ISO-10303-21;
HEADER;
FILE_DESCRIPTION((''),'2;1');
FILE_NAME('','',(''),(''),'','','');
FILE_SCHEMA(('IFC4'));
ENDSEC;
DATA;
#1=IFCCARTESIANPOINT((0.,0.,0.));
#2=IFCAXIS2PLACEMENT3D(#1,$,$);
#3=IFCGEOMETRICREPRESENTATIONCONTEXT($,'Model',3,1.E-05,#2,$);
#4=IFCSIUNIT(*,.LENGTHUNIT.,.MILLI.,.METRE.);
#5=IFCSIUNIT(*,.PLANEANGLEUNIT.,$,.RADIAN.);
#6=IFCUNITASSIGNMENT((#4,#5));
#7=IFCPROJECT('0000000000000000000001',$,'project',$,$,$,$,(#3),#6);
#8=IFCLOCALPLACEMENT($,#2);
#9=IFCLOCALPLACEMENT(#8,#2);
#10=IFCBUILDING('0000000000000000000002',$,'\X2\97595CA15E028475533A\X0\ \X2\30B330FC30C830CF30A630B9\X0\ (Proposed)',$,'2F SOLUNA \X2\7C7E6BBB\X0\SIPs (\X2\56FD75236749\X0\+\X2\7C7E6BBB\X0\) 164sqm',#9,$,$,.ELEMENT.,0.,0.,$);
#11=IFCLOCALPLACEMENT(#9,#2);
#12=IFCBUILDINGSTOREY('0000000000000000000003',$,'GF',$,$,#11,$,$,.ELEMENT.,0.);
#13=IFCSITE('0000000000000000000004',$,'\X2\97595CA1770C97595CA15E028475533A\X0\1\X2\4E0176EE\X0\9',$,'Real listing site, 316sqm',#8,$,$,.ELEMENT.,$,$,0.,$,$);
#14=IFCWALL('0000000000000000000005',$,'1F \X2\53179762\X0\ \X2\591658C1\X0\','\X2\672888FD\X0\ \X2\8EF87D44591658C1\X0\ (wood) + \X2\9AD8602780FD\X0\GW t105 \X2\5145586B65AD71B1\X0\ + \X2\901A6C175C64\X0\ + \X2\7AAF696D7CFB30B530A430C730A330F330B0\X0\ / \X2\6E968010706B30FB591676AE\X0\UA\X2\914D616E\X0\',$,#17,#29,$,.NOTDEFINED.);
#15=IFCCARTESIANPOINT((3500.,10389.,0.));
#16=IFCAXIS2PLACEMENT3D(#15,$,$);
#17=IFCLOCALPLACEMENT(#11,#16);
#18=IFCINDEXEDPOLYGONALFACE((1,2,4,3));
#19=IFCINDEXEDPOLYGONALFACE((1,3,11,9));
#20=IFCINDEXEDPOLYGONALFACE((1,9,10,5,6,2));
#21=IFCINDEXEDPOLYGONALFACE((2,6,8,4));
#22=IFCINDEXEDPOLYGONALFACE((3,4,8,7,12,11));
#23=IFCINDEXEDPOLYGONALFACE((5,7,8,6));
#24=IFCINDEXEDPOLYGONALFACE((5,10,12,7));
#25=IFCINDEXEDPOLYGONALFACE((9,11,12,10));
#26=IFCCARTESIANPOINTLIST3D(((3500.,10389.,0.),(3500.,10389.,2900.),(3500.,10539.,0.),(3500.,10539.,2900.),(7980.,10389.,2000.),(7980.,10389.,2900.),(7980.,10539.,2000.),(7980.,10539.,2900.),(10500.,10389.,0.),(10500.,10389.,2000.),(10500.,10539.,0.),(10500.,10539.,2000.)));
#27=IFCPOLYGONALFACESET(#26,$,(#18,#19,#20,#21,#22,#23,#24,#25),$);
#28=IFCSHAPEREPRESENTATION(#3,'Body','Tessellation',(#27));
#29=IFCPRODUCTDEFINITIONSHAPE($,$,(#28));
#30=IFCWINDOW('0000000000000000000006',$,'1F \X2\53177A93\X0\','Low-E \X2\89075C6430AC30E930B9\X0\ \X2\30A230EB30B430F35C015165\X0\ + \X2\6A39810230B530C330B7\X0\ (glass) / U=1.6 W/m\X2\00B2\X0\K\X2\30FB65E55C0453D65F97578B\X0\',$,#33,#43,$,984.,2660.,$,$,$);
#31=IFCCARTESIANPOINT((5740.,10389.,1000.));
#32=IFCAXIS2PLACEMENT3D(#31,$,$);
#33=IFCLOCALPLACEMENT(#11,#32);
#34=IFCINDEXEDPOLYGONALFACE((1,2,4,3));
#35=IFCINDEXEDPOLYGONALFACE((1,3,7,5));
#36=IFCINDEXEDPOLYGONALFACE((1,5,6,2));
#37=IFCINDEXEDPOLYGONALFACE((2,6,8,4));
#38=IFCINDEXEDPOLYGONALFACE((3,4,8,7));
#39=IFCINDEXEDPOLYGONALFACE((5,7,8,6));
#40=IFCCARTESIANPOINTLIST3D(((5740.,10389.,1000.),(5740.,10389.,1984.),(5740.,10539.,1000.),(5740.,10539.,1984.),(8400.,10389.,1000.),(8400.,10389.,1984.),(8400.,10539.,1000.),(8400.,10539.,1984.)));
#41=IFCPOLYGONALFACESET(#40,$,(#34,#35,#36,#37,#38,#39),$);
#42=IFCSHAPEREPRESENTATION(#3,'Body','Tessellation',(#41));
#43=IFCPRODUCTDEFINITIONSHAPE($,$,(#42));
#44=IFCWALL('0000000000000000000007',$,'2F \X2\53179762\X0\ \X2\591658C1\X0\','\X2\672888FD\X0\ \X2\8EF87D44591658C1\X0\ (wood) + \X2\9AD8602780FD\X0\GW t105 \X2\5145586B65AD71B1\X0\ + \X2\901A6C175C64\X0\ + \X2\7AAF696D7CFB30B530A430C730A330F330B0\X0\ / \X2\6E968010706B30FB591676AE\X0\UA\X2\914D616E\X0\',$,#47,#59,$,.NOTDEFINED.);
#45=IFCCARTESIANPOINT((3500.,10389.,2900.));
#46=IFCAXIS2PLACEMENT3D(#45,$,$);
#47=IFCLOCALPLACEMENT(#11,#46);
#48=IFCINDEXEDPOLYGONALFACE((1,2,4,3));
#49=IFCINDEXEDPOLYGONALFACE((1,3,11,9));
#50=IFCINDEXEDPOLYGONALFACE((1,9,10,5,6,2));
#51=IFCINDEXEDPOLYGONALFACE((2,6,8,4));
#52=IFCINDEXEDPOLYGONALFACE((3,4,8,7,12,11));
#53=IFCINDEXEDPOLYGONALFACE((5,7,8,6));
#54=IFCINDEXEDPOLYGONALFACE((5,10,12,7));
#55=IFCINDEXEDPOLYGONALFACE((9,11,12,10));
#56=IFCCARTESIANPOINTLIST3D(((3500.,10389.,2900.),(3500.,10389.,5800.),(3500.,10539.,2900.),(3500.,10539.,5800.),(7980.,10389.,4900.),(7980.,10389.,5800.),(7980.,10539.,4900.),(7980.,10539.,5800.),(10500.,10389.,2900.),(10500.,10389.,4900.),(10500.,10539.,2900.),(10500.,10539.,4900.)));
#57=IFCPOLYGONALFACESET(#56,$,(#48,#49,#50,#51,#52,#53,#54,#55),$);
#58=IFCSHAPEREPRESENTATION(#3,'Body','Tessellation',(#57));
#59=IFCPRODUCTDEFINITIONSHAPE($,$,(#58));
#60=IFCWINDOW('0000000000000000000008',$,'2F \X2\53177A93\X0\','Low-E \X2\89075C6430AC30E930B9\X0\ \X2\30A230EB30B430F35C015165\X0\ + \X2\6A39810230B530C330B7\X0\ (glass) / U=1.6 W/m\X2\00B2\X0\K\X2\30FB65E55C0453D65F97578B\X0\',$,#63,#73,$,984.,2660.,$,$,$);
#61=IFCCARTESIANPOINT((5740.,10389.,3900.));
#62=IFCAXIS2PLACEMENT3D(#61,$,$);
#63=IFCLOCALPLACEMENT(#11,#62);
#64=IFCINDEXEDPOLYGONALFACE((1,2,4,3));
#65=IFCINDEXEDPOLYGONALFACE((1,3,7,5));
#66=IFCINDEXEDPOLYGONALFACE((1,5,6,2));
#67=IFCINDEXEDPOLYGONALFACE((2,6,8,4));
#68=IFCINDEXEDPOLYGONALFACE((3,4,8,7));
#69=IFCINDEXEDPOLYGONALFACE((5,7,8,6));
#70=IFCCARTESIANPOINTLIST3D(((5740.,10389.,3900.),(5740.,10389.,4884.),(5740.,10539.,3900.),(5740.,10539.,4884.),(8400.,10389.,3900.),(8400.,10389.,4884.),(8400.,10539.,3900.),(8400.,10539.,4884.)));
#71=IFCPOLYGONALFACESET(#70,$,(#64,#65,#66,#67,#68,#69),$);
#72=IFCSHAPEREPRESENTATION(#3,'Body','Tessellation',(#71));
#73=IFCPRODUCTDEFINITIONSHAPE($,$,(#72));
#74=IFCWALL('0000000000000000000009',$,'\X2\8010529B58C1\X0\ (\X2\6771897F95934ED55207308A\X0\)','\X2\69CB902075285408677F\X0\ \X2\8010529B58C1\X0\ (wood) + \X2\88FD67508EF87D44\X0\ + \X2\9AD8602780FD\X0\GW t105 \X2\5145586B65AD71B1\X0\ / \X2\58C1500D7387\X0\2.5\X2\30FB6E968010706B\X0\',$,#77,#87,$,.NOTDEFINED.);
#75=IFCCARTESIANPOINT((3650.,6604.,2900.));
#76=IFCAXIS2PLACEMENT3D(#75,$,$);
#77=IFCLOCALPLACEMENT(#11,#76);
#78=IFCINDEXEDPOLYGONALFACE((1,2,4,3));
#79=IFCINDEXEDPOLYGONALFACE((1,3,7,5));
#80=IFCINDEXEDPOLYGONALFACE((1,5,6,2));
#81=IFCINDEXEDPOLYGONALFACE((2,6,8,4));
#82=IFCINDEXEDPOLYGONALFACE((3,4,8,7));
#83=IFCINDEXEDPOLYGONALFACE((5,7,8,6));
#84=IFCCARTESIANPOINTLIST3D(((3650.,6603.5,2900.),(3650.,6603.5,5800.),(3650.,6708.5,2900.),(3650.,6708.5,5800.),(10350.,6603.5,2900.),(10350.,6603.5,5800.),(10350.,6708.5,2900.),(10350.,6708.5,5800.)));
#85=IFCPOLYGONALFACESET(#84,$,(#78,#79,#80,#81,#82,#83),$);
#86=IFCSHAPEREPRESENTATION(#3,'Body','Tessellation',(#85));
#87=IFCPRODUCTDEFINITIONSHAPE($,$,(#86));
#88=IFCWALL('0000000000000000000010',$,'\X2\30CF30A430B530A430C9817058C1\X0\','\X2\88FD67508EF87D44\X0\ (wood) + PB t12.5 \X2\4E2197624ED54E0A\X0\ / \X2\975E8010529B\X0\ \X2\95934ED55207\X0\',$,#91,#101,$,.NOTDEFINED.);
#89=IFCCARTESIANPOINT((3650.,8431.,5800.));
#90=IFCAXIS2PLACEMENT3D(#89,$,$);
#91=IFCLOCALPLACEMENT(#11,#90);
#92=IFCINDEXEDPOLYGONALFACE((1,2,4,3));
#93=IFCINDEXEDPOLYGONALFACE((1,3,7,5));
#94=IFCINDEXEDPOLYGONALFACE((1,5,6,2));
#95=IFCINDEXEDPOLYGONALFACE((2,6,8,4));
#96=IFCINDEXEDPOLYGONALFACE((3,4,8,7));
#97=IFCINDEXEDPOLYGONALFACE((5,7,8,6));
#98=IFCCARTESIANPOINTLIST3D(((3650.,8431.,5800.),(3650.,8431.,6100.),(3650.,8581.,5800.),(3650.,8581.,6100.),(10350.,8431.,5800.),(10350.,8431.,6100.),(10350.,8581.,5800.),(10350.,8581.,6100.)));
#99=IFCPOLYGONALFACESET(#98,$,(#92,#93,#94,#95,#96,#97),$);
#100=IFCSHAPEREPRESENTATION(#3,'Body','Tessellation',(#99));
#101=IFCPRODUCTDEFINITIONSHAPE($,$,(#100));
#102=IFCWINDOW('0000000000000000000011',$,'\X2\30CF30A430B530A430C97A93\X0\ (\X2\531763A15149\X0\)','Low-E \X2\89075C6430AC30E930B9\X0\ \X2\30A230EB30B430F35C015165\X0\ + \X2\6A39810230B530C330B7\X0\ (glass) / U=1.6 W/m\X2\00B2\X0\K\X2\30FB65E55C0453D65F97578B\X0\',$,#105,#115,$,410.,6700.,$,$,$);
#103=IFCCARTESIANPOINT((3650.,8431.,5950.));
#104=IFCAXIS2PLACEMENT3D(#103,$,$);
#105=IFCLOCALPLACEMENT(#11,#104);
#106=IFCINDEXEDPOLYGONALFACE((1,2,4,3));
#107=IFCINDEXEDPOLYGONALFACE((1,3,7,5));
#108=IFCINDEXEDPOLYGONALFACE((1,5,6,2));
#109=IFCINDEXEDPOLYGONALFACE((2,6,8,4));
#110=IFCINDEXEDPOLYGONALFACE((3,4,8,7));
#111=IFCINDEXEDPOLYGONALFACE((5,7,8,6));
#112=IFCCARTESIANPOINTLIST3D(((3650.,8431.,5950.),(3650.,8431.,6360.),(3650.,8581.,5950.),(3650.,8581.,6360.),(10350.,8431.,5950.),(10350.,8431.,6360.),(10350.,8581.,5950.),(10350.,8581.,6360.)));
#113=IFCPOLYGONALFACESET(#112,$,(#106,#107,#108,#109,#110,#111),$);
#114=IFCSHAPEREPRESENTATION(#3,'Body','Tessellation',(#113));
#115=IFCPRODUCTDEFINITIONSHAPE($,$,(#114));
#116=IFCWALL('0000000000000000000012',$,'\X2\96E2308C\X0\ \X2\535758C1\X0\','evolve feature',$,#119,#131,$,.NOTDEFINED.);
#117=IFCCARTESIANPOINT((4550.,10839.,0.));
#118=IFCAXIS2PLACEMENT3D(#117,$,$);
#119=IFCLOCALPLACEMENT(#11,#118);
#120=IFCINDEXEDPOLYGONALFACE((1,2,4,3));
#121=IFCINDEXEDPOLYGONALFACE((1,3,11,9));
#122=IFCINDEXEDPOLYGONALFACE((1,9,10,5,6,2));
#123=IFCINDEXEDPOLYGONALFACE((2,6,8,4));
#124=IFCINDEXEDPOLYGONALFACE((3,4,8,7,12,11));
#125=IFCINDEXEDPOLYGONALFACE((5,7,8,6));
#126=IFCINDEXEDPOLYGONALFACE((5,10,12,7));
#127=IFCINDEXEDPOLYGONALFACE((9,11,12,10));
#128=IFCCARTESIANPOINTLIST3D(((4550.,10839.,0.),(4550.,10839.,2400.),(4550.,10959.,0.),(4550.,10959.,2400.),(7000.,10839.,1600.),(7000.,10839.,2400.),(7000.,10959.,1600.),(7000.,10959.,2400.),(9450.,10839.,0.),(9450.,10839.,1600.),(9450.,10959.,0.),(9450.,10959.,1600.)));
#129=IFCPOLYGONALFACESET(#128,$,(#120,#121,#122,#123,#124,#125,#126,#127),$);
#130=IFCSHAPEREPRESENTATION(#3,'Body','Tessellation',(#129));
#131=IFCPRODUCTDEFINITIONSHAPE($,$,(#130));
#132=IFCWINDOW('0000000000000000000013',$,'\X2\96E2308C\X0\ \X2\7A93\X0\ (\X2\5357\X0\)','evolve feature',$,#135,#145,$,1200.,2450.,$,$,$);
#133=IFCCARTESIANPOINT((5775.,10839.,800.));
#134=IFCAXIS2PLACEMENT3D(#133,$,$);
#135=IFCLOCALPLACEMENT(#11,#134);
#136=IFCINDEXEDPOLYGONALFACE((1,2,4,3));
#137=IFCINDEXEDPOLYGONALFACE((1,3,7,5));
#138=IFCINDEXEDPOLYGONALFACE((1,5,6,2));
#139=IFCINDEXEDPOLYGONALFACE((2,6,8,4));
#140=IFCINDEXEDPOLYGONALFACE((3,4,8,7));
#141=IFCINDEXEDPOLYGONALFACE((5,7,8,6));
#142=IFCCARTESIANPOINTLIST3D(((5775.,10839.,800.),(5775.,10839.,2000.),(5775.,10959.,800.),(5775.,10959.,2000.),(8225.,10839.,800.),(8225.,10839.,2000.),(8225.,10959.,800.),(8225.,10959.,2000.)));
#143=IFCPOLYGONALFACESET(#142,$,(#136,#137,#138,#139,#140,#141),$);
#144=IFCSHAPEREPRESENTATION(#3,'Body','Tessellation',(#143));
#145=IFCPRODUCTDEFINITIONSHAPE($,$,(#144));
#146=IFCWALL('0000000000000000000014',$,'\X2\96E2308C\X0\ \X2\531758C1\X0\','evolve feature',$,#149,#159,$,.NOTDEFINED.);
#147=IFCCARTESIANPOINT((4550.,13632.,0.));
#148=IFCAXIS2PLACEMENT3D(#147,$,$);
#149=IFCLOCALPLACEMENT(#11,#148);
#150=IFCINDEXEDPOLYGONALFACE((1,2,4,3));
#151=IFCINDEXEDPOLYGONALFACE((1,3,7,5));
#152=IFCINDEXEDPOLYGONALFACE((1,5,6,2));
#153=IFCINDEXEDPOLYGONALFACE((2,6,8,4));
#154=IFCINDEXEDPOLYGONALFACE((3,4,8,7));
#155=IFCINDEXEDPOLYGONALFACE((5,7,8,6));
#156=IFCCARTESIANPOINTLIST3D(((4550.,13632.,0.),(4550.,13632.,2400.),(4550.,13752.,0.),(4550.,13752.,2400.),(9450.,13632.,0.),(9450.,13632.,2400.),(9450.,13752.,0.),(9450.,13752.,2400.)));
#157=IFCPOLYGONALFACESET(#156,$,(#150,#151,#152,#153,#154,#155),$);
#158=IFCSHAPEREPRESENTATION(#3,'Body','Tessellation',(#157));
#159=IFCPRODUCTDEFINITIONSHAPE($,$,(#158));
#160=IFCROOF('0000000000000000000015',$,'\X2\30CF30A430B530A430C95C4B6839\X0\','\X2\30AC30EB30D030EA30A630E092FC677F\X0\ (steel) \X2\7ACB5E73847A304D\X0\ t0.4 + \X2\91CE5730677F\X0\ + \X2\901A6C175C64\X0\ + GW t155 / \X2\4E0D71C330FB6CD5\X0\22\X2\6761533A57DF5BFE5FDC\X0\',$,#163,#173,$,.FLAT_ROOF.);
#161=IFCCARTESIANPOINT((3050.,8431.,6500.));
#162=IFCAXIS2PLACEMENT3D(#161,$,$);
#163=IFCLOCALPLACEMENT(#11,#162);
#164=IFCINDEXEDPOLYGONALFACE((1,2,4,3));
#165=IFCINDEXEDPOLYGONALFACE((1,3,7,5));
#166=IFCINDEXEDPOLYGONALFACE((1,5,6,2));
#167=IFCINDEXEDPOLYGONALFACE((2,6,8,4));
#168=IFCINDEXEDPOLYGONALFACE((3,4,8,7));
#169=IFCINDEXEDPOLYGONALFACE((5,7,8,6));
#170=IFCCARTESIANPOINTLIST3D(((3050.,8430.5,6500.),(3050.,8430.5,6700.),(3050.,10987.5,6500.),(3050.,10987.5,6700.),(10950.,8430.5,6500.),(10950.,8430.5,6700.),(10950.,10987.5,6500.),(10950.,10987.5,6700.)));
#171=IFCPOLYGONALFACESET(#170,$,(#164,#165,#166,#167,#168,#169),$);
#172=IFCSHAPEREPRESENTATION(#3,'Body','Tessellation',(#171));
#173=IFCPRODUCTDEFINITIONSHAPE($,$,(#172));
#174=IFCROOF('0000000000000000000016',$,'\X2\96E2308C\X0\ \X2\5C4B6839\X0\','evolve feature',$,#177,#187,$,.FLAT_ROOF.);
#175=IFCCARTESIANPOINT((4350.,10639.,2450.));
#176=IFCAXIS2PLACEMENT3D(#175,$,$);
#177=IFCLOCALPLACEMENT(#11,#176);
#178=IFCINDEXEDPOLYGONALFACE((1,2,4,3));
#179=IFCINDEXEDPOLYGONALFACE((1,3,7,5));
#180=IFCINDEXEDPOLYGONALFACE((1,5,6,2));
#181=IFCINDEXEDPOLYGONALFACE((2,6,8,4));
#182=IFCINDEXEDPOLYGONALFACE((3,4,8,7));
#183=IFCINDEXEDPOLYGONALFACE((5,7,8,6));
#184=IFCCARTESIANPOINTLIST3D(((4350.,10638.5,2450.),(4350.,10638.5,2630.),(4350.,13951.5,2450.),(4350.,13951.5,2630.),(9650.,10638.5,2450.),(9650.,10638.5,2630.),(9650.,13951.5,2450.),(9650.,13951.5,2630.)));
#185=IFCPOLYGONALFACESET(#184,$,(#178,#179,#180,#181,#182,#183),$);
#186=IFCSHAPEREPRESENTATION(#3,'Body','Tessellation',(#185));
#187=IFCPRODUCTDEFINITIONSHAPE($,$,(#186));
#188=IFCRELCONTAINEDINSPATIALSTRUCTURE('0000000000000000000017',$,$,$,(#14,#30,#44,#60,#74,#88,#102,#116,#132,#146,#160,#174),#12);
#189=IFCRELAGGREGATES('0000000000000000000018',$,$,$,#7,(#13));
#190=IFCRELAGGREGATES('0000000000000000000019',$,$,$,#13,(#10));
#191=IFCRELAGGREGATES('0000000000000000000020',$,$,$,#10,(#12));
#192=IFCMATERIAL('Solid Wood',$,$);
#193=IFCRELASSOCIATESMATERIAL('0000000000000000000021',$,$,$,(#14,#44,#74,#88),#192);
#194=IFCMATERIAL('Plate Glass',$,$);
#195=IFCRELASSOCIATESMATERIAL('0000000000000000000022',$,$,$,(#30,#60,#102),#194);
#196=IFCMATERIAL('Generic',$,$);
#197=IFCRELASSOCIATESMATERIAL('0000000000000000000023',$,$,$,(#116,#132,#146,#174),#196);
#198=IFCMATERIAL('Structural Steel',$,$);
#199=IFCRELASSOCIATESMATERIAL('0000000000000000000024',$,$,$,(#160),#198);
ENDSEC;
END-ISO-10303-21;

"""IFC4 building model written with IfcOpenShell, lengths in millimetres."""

from ifc_helpers import new_model, si_unit, frame, frame_2d, origin, place, context, project, spatial, rectangle, extrude, material, element, fill, save


model = new_model("IFC4")

# Units and contexts
model_context = context("Model", 3, precision=1e-05, world=origin())
ifc_project = project(units=[si_unit("LENGTHUNIT", "METRE", prefix="MILLI"), si_unit("PLANEANGLEUNIT", "RADIAN")], contexts=[model_context])

# Site, building, storey
site_placement = place(None, origin())
site = spatial("IfcSite", under=ifc_project, at=site_placement, Name="静岡県静岡市葵区1丁目9", ObjectType="Real listing site, 316sqm", CompositionType="ELEMENT", RefElevation=0.0)
building_placement = place(site_placement, origin())
building = spatial("IfcBuilding", under=site, at=building_placement, Name="静岡市葵区 コートハウス (Proposed)", ObjectType="2F SOLUNA 籾殻SIPs (国産杉+籾殻) 164sqm", CompositionType="ELEMENT", ElevationOfRefHeight=0.0, ElevationOfTerrain=0.0)
storey_placement = place(building_placement, origin())
storey = spatial("IfcBuildingStorey", under=building, at=storey_placement, Name="GF", CompositionType="ELEMENT", Elevation=0.0)

# Shared definitions
ifc_material_1 = material(Name="Generic")

# Wall, opening, window
ifc_material_2 = material(Name="Solid Wood")
wall_1_placement = place(storey_placement, frame((3500.0, 10389.0, 0.0)))
wall_1 = element("IfcWall", 1, at=wall_1_placement, inside=storey, material=ifc_material_2, Name="1F 北面 外壁", Description="木製 軸組外壁 (wood) + 高性能GW t105 充填断熱 + 通気層 + 窯業系サイディング / 準耐火・外皮UA配慮", PredefinedType="NOTDEFINED", context=model_context, shape_type="SweptSolid", body=[
    extrude(rectangle(XDim=7000.0, YDim=150.0, at=frame_2d((3500.0, 75.0))), frame((3500.0, 10389.0, 0.0)), (0.0, 0.0, 1.0), 2900.0),
])
opening_1_placement = place(storey_placement, frame((5740.0, 10389.0, 1000.0)))
opening_1 = element("IfcOpeningElement", 2, at=opening_1_placement, cuts=wall_1, PredefinedType="NOTDEFINED", context=model_context, shape_type="SweptSolid", body=[
    extrude(rectangle(XDim=2660.0, YDim=150.0, at=frame_2d((1330.0, 75.0))), frame((5740.0, 10389.0, 1000.0)), (0.0, 0.0, 1.0), 984.0),
])
ifc_material_3 = material(Name="Plate Glass")
window_1_placement = place(storey_placement, frame((5740.0, 10389.0, 1000.0)))
window_1 = element("IfcWindow", 3, at=window_1_placement, inside=storey, material=ifc_material_3, Name="1F 北窓", Description="Low-E 複層ガラス アルゴン封入 + 樹脂サッシ (glass) / U=1.6 W/m²K・日射取得型", OverallHeight=984.0, OverallWidth=2660.0, context=model_context, shape_type="SweptSolid", body=[
    extrude(rectangle(XDim=2660.0, YDim=150.0, at=frame_2d((1330.0, 75.0))), frame((5740.0, 10389.0, 1000.0)), (0.0, 0.0, 1.0), 984.0),
])
fill(opening_1, window_1)

# Wall, opening, window
wall_2_placement = place(storey_placement, frame((3500.0, 10389.0, 2900.0)))
wall_2 = element("IfcWall", 4, at=wall_2_placement, inside=storey, material=ifc_material_2, Name="2F 北面 外壁", Description="木製 軸組外壁 (wood) + 高性能GW t105 充填断熱 + 通気層 + 窯業系サイディング / 準耐火・外皮UA配慮", PredefinedType="NOTDEFINED", context=model_context, shape_type="SweptSolid", body=[
    extrude(rectangle(XDim=7000.0, YDim=150.0, at=frame_2d((3500.0, 75.0))), frame((3500.0, 10389.0, 2900.0)), (0.0, 0.0, 1.0), 2900.0),
])
opening_2_placement = place(storey_placement, frame((5740.0, 10389.0, 3900.0)))
opening_2 = element("IfcOpeningElement", 5, at=opening_2_placement, cuts=wall_2, PredefinedType="NOTDEFINED", context=model_context, shape_type="SweptSolid", body=[
    extrude(rectangle(XDim=2660.0, YDim=150.0, at=frame_2d((1330.0, 75.0))), frame((5740.0, 10389.0, 3900.0)), (0.0, 0.0, 1.0), 984.0),
])
window_2_placement = place(storey_placement, frame((5740.0, 10389.0, 3900.0)))
window_2 = element("IfcWindow", 6, at=window_2_placement, inside=storey, material=ifc_material_3, Name="2F 北窓", Description="Low-E 複層ガラス アルゴン封入 + 樹脂サッシ (glass) / U=1.6 W/m²K・日射取得型", OverallHeight=984.0, OverallWidth=2660.0, context=model_context, shape_type="SweptSolid", body=[
    extrude(rectangle(XDim=2660.0, YDim=150.0, at=frame_2d((1330.0, 75.0))), frame((5740.0, 10389.0, 3900.0)), (0.0, 0.0, 1.0), 984.0),
])
fill(opening_2, window_2)

# Wall
wall_3_placement = place(storey_placement, frame((3650.0, 6604.0, 2900.0)))
element("IfcWall", 7, at=wall_3_placement, inside=storey, material=ifc_material_2, Name="耐力壁 (東西間仕切り)", Description="構造用合板 耐力壁 (wood) + 製材軸組 + 高性能GW t105 充填断熱 / 壁倍率2.5・準耐火", PredefinedType="NOTDEFINED", context=model_context, shape_type="SweptSolid", body=[
    extrude(rectangle(XDim=6700.0, YDim=105.0, at=frame_2d((3350.0, 52.0))), frame((3650.0, 6604.0, 2900.0)), (0.0, 0.0, 1.0), 2900.0),
])

# Walls, openings, windows
wall_4_placement = place(storey_placement, frame((3650.0, 8431.0, 5800.0)))
wall_4 = element("IfcWall", 8, at=wall_4_placement, inside=storey, material=ifc_material_2, Name="ハイサイド腰壁", Description="製材軸組 (wood) + PB t12.5 両面仕上 / 非耐力 間仕切", PredefinedType="NOTDEFINED", context=model_context, shape_type="SweptSolid", body=[
    extrude(rectangle(XDim=6700.0, YDim=150.0, at=frame_2d((3350.0, 75.0))), frame((3650.0, 8431.0, 5800.0)), (0.0, 0.0, 1.0), 700.0),
])
opening_3_placement = place(storey_placement, frame((3650.0, 8431.0, 5950.0)))
opening_3 = element("IfcOpeningElement", 9, at=opening_3_placement, cuts=wall_4, PredefinedType="NOTDEFINED", context=model_context, shape_type="SweptSolid", body=[
    extrude(rectangle(XDim=6700.0, YDim=150.0, at=frame_2d((3350.0, 75.0))), frame((3650.0, 8431.0, 5950.0)), (0.0, 0.0, 1.0), 410.0),
])
window_3_placement = place(storey_placement, frame((3650.0, 8431.0, 5950.0)))
window_3 = element("IfcWindow", 10, at=window_3_placement, inside=storey, material=ifc_material_3, Name="ハイサイド窓 (北採光)", Description="Low-E 複層ガラス アルゴン封入 + 樹脂サッシ (glass) / U=1.6 W/m²K・日射取得型", OverallHeight=410.0, OverallWidth=6700.0, context=model_context, shape_type="SweptSolid", body=[
    extrude(rectangle(XDim=6700.0, YDim=150.0, at=frame_2d((3350.0, 75.0))), frame((3650.0, 8431.0, 5950.0)), (0.0, 0.0, 1.0), 410.0),
])
fill(opening_3, window_3)
wall_5_placement = place(storey_placement, frame((4550.0, 10839.0, 0.0)))
wall_5 = element("IfcWall", 11, at=wall_5_placement, inside=storey, material=ifc_material_1, Name="離れ 南壁", Description="evolve feature", PredefinedType="NOTDEFINED", context=model_context, shape_type="SweptSolid", body=[
    extrude(rectangle(XDim=4900.0, YDim=120.0, at=frame_2d((2450.0, 60.0))), frame((4550.0, 10839.0, 0.0)), (0.0, 0.0, 1.0), 2400.0),
])
opening_4_placement = place(storey_placement, frame((5775.0, 10839.0, 800.0)))
opening_4 = element("IfcOpeningElement", 12, at=opening_4_placement, cuts=wall_5, PredefinedType="NOTDEFINED", context=model_context, shape_type="SweptSolid", body=[
    extrude(rectangle(XDim=2450.0, YDim=120.0, at=frame_2d((1225.0, 60.0))), frame((5775.0, 10839.0, 800.0)), (0.0, 0.0, 1.0), 1200.0),
])
window_4_placement = place(storey_placement, frame((5775.0, 10839.0, 800.0)))
window_4 = element("IfcWindow", 13, at=window_4_placement, inside=storey, material=ifc_material_1, Name="離れ 窓 (南)", Description="evolve feature", OverallHeight=1200.0, OverallWidth=2450.0, context=model_context, shape_type="SweptSolid", body=[
    extrude(rectangle(XDim=2450.0, YDim=120.0, at=frame_2d((1225.0, 60.0))), frame((5775.0, 10839.0, 800.0)), (0.0, 0.0, 1.0), 1200.0),
])
fill(opening_4, window_4)

# Wall
wall_6_placement = place(storey_placement, frame((4550.0, 13632.0, 0.0)))
element("IfcWall", 14, at=wall_6_placement, inside=storey, material=ifc_material_1, Name="離れ 北壁", Description="evolve feature", PredefinedType="NOTDEFINED", context=model_context, shape_type="SweptSolid", body=[
    extrude(rectangle(XDim=4900.0, YDim=120.0, at=frame_2d((2450.0, 60.0))), frame((4550.0, 13632.0, 0.0)), (0.0, 0.0, 1.0), 2400.0),
])

# Roofs
ifc_material_4 = material(Name="Structural Steel")
roof_1_placement = place(storey_placement, frame((3050.0, 8431.0, 6500.0)))
element("IfcRoof", 15, at=roof_1_placement, inside=storey, material=ifc_material_4, Name="ハイサイド屋根", Description="ガルバリウム鋼板 (steel) 立平葺き t0.4 + 野地板 + 通気層 + GW t155 / 不燃・法22条区域対応", PredefinedType="FLAT_ROOF", context=model_context, shape_type="SweptSolid", body=[
    extrude(rectangle(XDim=7900.0, YDim=2557.0, at=frame_2d((3950.0, 1278.0))), frame((3050.0, 8431.0, 6500.0)), (0.0, 0.0, 1.0), 200.0),
])
roof_2_placement = place(storey_placement, frame((4350.0, 10639.0, 2450.0)))
element("IfcRoof", 16, at=roof_2_placement, inside=storey, material=ifc_material_1, Name="離れ 屋根", Description="evolve feature", PredefinedType="FLAT_ROOF", context=model_context, shape_type="SweptSolid", body=[
    extrude(rectangle(XDim=5300.0, YDim=3313.0, at=frame_2d((2650.0, 1656.0))), frame((4350.0, 10639.0, 2450.0)), (0.0, 0.0, 1.0), 180.0),
])

save(model, "model.ifc")
